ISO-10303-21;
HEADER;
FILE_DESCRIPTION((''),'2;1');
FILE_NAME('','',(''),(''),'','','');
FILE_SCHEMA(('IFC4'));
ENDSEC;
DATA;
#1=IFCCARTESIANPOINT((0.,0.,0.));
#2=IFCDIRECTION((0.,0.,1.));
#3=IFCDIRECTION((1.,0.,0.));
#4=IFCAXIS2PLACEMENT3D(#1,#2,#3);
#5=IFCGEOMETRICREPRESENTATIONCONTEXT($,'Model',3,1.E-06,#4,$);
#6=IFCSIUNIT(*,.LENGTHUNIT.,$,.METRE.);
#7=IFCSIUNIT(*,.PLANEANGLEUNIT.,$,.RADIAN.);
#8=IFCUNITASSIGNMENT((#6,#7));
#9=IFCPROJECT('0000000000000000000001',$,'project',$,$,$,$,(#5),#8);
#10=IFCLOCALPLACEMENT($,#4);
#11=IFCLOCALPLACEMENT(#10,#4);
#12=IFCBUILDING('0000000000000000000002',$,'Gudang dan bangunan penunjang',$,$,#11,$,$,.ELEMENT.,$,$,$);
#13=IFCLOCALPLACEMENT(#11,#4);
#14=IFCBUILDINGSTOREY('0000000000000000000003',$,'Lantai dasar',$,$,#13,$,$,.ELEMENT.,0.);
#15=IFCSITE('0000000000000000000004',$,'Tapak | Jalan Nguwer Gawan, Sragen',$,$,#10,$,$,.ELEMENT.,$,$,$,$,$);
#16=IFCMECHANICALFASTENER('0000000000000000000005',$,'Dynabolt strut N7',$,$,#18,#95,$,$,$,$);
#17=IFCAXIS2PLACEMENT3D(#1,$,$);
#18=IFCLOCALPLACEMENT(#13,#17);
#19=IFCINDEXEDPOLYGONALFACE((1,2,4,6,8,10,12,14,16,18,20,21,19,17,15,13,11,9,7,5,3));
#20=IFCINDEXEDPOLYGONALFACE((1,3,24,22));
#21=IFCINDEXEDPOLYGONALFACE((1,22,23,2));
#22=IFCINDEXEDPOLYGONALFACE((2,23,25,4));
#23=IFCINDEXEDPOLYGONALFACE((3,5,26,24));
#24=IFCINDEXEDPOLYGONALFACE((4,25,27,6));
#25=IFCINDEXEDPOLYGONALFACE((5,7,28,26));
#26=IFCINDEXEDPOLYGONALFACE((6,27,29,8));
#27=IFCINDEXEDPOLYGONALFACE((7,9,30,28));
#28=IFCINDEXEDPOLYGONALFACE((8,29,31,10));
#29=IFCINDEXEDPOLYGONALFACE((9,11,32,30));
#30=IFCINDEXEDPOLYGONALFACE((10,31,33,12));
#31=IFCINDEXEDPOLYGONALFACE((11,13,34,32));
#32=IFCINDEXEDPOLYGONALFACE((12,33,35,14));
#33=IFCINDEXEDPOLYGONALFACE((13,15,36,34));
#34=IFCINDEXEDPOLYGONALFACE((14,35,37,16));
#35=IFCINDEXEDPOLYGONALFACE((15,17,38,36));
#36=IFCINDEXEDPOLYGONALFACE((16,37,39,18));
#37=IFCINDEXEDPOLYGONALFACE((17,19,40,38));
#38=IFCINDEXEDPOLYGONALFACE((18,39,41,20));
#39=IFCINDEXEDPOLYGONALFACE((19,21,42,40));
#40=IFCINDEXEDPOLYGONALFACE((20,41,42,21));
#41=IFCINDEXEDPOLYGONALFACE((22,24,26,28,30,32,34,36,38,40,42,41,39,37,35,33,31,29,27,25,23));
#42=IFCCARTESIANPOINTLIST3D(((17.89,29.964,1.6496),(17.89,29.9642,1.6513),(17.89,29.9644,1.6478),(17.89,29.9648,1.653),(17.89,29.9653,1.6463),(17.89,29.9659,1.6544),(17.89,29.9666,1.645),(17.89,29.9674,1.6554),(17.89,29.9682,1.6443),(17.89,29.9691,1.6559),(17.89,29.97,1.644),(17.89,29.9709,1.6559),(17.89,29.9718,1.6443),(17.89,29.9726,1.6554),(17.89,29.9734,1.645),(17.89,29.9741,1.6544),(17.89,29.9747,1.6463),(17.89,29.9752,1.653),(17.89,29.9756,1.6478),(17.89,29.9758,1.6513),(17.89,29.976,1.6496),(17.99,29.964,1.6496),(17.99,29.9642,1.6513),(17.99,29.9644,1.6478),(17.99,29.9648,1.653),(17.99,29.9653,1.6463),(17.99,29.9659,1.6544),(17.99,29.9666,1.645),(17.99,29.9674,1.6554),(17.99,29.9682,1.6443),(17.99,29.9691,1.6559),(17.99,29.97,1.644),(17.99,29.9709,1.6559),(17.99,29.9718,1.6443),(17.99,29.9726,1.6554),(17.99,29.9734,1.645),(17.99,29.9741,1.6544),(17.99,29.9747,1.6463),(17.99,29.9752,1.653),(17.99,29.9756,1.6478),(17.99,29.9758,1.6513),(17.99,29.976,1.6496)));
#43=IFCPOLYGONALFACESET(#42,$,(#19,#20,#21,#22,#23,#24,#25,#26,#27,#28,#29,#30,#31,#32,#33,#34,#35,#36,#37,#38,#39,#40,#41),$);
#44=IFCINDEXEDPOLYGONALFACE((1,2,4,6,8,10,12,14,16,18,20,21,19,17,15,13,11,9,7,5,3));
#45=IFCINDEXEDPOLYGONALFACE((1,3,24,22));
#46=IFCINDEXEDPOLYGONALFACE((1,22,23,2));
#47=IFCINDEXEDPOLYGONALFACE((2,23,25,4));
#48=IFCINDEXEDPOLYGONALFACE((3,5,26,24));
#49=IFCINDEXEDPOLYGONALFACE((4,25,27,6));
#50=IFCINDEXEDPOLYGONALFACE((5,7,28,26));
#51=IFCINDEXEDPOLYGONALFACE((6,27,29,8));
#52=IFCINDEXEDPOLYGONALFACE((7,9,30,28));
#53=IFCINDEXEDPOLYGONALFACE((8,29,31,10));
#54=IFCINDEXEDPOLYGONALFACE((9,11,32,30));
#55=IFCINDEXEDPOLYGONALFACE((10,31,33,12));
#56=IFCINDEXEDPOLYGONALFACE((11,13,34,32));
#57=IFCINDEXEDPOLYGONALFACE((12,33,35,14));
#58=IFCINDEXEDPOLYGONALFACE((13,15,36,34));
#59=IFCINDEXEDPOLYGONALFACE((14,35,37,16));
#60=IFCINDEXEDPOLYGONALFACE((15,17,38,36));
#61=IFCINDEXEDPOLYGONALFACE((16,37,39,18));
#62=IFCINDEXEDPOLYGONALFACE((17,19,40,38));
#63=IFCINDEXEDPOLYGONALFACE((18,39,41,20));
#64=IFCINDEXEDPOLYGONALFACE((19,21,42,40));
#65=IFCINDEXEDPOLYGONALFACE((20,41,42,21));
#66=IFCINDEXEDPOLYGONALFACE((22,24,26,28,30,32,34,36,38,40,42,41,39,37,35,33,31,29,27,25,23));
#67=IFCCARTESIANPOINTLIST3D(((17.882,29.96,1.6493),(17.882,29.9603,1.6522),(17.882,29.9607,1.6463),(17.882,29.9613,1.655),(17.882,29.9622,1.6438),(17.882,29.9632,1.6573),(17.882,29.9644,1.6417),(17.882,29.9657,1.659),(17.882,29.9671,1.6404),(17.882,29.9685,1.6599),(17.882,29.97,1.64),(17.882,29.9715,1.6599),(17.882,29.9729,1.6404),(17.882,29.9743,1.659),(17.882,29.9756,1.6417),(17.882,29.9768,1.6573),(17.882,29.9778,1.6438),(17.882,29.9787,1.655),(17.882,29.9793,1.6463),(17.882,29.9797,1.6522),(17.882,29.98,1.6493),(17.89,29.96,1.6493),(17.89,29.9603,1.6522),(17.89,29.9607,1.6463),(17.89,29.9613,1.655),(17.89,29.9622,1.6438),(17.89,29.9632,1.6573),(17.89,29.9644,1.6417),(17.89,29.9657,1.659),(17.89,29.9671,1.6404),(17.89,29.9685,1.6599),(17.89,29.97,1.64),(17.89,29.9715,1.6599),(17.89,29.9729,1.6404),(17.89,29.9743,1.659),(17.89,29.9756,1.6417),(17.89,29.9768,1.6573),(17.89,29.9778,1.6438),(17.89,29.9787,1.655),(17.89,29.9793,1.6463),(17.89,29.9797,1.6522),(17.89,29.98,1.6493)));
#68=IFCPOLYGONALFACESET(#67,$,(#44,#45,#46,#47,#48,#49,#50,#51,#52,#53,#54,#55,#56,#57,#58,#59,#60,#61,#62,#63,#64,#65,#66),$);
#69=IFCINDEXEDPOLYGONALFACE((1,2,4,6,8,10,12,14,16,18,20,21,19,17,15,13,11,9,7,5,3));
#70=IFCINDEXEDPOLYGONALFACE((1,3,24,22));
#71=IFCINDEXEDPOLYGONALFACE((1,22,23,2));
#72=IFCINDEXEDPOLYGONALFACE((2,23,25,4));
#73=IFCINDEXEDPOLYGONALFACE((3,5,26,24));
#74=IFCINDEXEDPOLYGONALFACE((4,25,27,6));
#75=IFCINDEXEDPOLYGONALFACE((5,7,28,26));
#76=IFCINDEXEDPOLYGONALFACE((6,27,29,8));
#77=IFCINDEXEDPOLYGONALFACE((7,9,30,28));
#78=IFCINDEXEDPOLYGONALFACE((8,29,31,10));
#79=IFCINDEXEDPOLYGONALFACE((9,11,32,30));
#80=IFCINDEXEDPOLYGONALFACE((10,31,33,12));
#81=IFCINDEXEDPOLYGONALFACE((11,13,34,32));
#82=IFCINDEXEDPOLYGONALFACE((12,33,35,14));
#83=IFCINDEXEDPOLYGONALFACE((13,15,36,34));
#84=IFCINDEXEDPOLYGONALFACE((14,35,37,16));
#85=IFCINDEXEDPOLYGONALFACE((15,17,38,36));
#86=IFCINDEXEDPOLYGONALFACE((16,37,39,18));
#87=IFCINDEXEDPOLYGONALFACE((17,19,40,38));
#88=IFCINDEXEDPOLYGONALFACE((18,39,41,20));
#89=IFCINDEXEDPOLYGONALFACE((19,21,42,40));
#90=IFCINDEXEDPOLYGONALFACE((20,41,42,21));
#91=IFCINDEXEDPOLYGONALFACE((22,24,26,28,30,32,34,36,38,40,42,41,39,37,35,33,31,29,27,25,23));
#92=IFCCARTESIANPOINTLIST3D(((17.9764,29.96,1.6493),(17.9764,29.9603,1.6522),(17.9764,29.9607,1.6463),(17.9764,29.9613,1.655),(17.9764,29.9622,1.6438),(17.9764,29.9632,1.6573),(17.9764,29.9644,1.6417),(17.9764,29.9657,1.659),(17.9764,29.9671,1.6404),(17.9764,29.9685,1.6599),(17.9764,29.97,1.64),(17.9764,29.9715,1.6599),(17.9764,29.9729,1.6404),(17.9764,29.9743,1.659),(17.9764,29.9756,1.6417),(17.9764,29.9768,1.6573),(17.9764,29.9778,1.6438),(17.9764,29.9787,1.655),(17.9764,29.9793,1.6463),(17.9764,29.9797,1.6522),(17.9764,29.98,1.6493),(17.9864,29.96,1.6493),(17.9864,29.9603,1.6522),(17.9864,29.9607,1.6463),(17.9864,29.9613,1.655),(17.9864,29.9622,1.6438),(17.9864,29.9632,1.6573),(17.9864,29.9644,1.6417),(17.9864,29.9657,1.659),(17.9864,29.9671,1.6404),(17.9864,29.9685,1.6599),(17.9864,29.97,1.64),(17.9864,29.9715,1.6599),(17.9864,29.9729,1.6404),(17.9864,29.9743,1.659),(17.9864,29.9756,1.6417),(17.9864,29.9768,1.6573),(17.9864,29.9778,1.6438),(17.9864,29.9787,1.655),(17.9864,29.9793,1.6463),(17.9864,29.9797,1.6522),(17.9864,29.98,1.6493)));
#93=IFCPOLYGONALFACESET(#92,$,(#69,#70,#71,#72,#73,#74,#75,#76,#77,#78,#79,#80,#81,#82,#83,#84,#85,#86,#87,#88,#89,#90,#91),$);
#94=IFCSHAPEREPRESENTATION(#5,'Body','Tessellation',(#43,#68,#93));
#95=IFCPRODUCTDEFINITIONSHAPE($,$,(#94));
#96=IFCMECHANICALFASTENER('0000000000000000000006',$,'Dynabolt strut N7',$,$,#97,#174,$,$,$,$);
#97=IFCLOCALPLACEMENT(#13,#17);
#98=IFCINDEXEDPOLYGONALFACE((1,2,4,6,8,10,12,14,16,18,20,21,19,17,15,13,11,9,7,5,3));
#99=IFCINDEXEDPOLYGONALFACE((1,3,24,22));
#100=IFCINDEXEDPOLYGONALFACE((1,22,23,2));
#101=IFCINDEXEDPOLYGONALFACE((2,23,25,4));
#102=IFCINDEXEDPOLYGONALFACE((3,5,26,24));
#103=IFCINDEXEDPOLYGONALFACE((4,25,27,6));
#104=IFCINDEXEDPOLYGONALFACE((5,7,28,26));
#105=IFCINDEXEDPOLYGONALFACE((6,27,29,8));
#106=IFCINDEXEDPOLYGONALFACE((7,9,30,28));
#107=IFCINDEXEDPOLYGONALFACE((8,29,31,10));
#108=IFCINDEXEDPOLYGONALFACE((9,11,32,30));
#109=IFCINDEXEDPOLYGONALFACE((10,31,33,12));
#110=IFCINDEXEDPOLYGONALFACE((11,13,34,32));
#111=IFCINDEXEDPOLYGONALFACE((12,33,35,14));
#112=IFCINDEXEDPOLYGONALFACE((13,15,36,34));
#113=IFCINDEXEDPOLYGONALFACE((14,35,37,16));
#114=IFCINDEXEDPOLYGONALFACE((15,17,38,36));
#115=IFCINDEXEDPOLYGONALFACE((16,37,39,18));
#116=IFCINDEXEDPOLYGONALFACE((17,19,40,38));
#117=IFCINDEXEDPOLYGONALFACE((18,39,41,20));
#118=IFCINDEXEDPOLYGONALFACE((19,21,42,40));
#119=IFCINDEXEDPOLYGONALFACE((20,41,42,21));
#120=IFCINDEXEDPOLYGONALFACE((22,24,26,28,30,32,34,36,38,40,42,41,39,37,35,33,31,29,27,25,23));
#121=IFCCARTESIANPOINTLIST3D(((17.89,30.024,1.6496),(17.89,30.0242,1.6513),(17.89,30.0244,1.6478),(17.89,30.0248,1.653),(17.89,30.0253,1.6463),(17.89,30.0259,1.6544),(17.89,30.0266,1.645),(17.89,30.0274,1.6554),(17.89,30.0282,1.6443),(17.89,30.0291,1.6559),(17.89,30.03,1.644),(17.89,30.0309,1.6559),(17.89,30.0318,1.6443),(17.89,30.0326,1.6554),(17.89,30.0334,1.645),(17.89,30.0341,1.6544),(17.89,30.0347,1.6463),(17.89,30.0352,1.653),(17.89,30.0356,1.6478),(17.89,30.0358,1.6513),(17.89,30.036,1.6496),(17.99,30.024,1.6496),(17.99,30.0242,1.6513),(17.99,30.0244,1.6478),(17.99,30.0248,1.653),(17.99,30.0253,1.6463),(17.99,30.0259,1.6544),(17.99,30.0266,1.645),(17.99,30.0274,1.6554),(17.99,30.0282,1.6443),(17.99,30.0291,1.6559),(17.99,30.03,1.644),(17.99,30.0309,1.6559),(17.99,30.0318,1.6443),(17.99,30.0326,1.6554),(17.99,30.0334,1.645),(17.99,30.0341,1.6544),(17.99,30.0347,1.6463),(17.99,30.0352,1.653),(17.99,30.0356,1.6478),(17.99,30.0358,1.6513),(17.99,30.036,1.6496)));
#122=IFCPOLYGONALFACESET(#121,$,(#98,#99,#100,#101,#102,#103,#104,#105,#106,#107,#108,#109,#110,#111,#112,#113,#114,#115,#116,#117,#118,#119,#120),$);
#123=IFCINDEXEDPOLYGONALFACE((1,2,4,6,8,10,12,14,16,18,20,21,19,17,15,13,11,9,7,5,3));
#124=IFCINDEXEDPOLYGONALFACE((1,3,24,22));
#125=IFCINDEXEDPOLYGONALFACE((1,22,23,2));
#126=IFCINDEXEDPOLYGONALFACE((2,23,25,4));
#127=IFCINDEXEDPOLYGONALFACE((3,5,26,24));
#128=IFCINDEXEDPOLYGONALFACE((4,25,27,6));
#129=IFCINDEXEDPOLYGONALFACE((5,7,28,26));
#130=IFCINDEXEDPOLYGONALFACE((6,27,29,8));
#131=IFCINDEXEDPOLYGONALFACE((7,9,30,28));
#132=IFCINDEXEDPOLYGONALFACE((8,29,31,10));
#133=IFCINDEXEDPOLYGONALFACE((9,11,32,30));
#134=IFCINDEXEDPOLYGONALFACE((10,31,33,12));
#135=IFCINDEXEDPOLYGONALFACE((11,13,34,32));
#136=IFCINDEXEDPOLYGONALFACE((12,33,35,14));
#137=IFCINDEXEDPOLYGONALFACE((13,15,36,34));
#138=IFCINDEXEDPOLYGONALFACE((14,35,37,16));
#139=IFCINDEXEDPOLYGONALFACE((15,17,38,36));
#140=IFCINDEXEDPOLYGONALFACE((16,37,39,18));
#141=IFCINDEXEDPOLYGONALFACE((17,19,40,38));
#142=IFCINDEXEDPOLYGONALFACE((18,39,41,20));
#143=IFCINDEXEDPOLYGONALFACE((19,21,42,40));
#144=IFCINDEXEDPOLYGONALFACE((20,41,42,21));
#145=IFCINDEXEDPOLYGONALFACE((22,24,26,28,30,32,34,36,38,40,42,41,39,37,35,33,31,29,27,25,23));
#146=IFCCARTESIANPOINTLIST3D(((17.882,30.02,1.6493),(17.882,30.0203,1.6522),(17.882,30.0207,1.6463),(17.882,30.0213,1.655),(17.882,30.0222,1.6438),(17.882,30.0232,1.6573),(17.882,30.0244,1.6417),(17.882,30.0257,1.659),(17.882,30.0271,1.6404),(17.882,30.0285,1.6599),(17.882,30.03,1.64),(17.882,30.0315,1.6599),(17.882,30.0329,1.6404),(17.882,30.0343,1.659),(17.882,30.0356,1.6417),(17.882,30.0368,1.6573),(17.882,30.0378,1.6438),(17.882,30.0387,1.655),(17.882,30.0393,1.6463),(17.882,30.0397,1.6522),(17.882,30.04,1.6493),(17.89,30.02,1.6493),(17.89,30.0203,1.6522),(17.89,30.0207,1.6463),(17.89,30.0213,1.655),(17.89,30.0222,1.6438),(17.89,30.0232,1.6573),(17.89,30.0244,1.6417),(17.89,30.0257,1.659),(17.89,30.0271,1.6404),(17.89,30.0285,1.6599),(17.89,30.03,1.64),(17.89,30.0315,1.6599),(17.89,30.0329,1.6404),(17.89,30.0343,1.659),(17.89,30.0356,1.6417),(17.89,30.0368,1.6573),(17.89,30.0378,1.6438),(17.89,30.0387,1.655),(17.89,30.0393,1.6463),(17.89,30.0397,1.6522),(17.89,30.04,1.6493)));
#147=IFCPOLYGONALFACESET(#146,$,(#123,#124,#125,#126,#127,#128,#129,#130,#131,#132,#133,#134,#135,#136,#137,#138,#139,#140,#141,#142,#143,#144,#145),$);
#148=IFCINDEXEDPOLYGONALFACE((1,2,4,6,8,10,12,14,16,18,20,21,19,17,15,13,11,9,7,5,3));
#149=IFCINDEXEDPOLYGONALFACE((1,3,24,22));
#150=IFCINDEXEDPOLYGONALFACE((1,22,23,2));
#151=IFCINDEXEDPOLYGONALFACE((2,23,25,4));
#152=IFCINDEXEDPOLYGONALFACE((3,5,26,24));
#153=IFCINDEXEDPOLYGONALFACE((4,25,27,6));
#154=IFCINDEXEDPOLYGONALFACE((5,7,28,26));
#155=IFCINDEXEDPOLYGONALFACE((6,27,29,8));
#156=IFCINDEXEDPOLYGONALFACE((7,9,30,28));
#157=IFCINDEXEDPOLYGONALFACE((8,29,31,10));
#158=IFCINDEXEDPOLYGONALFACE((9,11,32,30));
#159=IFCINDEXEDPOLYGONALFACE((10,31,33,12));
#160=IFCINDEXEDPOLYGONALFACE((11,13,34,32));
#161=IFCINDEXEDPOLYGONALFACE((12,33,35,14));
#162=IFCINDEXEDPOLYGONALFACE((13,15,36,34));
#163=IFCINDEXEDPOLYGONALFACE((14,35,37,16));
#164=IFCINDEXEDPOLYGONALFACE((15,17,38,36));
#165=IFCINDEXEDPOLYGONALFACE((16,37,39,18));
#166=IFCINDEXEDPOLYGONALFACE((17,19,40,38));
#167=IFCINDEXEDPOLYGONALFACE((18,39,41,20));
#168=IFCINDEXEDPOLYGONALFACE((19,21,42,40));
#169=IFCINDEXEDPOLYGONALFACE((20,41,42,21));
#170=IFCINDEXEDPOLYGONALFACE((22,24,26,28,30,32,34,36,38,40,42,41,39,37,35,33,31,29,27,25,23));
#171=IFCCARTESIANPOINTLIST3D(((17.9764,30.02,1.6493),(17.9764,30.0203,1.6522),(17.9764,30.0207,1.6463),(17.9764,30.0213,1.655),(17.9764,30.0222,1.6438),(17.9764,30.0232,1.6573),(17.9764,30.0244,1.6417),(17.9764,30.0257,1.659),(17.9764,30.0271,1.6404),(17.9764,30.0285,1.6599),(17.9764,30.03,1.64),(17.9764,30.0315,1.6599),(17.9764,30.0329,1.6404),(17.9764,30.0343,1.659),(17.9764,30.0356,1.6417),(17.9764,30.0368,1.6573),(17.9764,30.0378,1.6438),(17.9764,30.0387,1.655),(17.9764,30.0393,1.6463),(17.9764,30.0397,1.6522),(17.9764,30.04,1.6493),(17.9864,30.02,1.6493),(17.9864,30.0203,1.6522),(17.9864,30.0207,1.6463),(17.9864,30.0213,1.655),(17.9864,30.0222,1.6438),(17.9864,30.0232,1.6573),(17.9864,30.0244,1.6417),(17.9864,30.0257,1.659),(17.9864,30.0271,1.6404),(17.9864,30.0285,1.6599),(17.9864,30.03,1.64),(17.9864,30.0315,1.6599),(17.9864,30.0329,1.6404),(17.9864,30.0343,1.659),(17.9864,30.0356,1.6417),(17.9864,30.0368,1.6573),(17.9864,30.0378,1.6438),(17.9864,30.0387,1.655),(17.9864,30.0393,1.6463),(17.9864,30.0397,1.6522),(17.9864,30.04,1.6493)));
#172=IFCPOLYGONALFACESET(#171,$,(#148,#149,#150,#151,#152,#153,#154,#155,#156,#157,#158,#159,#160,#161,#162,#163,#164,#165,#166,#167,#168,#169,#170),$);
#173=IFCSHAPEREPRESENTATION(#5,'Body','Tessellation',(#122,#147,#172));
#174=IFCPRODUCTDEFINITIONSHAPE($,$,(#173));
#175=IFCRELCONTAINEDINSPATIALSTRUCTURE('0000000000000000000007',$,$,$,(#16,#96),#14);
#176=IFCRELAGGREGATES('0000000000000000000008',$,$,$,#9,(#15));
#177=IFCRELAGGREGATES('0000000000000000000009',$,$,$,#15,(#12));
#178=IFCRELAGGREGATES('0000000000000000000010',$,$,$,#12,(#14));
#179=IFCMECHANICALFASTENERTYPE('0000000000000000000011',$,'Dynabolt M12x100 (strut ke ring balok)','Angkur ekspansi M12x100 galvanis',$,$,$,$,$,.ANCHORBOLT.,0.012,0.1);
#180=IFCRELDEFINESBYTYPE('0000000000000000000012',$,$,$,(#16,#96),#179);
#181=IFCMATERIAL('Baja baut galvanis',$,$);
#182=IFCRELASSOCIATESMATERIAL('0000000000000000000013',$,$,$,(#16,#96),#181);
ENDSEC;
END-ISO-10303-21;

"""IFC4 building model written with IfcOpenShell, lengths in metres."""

from ifc_helpers import new_model, si_unit, frame, origin_with_axes, place, context, project, spatial, circle, extrude, source, transform, mapped, material, type_object, type_shapes, element, save


model = new_model("IFC4")

# Units and contexts
model_context = context("Model", 3, precision=1e-06, world=origin_with_axes())
ifc_project = project(units=[si_unit("LENGTHUNIT", "METRE"), si_unit("PLANEANGLEUNIT", "RADIAN")], contexts=[model_context])

# Site, building, storey
site_placement = place(None, origin_with_axes())
site = spatial("IfcSite", under=ifc_project, at=site_placement, Name="Tapak | Jalan Nguwer Gawan, Sragen", CompositionType="ELEMENT")
building_placement = place(site_placement, origin_with_axes())
building = spatial("IfcBuilding", under=site, at=building_placement, Name="Gudang dan bangunan penunjang", CompositionType="ELEMENT")
storey_placement = place(building_placement, origin_with_axes())
storey = spatial("IfcBuildingStorey", under=building, at=storey_placement, Name="Lantai dasar", CompositionType="ELEMENT", Elevation=0.0)

# Mechanical fasteners
ifc_material = material(Name="Baja baut galvanis")
mechanical_fastener_type = type_object("IfcMechanicalFastenerType", Name="Dynabolt M12x100 (strut ke ring balok)", Description="Angkur ekspansi M12x100 galvanis", NominalDiameter=0.012, NominalLength=0.1, PredefinedType="ANCHORBOLT")
shared_shape = source(origin_with_axes(), model_context, "Body", "SweptSolid", [
    extrude(circle(Radius=0.006), origin_with_axes(), (0.0, 0.0, 1.0), 0.1),
    extrude(circle(Radius=0.01), frame((0.0, 0.0, -0.008), z_axis=(0.0, 0.0, 1.0), x_axis=(1.0, 0.0, 0.0)), (0.0, 0.0, 1.0), 0.008),
    extrude(circle(Radius=0.01), frame((0.0, 0.0, 0.0864), z_axis=(0.0, 0.0, 1.0), x_axis=(1.0, 0.0, 0.0)), (0.0, 0.0, 1.0), 0.01),
])
type_shapes(mechanical_fastener_type, [shared_shape])
placement = place(None, origin_with_axes())
element("IfcMechanicalFastener", 1, at=placement, inside=storey, type_object=mechanical_fastener_type, material=ifc_material, Name="Dynabolt strut N7", context=model_context, shape_type="MappedRepresentation", body=[
    mapped(shared_shape, transform((17.89, 29.97, 1.65), x_axis=(0.0, 0.0, -1.0), y_axis=(0.0, 1.0, 0.0), z_axis=(1.0, 0.0, 0.0), scale=1.0)),
])
element("IfcMechanicalFastener", 2, at=placement, inside=storey, type_object=mechanical_fastener_type, material=ifc_material, Name="Dynabolt strut N7", context=model_context, shape_type="MappedRepresentation", body=[
    mapped(shared_shape, transform((17.89, 30.03, 1.65), x_axis=(0.0, 0.0, -1.0), y_axis=(0.0, 1.0, 0.0), z_axis=(1.0, 0.0, 0.0), scale=1.0)),
])

save(model, "model.ifc")
